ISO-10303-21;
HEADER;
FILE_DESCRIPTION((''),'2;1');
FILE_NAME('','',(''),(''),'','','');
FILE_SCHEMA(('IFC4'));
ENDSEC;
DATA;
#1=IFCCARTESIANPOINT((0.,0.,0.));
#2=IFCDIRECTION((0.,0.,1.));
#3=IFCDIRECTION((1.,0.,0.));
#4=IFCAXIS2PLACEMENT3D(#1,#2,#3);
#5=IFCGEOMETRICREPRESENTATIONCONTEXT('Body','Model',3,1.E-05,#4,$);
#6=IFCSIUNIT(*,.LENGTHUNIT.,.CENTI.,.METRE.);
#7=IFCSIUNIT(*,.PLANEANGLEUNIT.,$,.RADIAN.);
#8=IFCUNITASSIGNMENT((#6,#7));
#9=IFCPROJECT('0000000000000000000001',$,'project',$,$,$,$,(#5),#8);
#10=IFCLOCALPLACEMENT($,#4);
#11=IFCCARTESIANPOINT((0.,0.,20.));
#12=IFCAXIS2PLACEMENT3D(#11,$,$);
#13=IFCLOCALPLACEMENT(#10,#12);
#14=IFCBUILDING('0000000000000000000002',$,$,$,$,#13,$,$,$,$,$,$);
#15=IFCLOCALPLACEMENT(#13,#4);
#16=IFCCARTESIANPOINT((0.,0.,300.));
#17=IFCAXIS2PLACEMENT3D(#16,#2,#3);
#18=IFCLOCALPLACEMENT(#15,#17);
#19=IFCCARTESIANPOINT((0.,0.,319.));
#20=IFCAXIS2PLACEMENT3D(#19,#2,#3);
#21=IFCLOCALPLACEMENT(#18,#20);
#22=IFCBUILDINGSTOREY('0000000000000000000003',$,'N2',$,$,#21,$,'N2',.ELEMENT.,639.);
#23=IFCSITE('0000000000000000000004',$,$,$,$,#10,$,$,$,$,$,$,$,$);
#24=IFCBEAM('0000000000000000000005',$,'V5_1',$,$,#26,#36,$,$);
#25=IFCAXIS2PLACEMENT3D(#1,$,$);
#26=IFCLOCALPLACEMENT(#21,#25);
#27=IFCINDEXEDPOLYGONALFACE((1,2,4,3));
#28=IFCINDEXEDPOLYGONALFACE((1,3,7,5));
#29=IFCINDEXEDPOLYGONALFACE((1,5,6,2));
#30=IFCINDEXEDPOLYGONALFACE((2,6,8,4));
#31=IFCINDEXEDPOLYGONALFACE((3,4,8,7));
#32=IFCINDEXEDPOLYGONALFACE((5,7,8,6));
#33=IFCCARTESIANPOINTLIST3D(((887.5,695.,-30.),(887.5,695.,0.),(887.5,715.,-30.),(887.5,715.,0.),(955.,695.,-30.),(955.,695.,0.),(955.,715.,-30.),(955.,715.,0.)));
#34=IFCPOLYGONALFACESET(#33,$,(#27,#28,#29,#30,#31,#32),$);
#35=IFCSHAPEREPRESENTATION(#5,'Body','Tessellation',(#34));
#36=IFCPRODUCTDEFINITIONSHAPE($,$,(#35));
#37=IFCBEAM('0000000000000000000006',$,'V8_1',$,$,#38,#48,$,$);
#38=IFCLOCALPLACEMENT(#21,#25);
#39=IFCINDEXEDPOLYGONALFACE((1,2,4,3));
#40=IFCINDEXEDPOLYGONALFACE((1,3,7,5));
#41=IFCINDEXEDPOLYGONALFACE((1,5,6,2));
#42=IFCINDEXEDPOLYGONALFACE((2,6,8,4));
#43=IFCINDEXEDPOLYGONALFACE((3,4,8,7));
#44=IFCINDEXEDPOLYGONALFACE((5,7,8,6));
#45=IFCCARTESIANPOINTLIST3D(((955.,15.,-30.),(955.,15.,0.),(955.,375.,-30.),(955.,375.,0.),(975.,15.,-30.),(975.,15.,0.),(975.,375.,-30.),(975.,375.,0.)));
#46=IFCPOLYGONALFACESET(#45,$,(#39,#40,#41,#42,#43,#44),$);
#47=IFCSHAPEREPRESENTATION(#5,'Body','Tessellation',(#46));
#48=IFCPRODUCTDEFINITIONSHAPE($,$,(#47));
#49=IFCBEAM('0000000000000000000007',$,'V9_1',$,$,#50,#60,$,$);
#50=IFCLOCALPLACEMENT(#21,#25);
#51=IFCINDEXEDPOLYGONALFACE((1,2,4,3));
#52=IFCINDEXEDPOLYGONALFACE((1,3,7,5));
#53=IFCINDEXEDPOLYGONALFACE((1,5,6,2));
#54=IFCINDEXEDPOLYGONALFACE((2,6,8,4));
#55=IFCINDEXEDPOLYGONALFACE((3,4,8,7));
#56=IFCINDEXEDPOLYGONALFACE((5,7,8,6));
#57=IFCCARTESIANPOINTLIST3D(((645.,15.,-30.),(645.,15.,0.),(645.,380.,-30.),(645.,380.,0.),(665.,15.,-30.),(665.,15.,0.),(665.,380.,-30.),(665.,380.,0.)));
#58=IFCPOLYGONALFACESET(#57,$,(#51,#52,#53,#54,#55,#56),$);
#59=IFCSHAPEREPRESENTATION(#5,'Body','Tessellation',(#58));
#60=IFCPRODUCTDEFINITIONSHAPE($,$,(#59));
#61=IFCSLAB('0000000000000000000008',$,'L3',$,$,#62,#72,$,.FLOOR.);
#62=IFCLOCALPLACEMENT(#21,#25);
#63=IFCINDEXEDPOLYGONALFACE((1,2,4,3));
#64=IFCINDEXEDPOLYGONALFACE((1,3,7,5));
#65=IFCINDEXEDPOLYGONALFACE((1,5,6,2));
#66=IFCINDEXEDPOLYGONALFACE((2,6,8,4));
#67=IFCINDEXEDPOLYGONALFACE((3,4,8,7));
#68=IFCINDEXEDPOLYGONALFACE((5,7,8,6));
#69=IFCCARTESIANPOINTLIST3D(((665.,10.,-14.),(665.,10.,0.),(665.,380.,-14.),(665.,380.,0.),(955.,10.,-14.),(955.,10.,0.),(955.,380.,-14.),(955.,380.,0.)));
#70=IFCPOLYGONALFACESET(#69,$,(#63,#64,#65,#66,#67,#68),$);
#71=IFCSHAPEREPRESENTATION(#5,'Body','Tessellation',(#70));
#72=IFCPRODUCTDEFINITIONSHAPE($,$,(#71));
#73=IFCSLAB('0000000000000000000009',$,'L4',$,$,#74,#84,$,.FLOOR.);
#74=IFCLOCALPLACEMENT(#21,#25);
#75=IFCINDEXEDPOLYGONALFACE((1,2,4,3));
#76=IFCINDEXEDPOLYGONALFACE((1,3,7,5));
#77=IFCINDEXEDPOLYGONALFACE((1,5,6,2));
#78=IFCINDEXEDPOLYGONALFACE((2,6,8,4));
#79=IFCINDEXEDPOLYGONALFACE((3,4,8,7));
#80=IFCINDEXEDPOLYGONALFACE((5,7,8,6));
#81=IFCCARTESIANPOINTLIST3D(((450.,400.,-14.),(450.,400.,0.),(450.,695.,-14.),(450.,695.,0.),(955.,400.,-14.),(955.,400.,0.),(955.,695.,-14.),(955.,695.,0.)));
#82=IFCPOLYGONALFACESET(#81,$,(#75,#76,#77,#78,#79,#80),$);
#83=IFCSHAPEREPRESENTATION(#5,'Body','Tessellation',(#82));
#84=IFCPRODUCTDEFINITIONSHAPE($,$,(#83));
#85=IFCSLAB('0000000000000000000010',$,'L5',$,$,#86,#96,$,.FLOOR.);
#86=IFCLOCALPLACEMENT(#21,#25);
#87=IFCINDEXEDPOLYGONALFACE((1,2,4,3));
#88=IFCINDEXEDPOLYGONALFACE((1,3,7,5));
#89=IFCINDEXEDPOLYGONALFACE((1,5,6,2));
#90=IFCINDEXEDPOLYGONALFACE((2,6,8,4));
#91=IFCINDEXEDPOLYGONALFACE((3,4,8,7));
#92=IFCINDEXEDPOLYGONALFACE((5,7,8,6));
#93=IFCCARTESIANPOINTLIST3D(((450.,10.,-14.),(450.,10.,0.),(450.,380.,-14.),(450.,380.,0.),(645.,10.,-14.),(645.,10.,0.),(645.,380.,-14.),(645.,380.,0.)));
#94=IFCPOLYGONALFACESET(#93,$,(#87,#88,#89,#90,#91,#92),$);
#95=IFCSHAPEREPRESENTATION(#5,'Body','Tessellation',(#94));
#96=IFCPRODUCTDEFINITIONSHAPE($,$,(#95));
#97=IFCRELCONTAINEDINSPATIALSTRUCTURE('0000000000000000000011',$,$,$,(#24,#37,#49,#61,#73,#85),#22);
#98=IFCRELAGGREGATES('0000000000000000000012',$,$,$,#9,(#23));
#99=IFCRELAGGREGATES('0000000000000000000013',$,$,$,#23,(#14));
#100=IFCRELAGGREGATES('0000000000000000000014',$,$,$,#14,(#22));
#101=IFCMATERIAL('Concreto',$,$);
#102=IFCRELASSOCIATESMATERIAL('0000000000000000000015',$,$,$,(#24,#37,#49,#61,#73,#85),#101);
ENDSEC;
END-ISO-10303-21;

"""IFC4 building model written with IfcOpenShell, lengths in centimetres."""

from ifc_helpers import new_model, si_unit, frame, origin_with_axes, origin_2d_with_axis, place, context, project, spatial, polyline, rectangle, outline, extrude, material, element, save


model = new_model("IFC4")

# Units and contexts
model_context = context("Model", 3, precision=1e-05, world=origin_with_axes(), identifier="Body")
ifc_project = project(units=[si_unit("LENGTHUNIT", "METRE", prefix="CENTI"), si_unit("PLANEANGLEUNIT", "RADIAN")], contexts=[model_context])

# Site, building, storey
site_placement = place(None, origin_with_axes())
site = spatial("IfcSite", under=ifc_project, at=site_placement)
building_placement = place(site_placement, frame((0.0, 0.0, 20.0)))
building = spatial("IfcBuilding", under=site, at=building_placement)
placement_1 = place(building_placement, origin_with_axes())
placement_2 = place(placement_1, frame((0.0, 0.0, 300.0), z_axis=(0.0, 0.0, 1.0), x_axis=(1.0, 0.0, 0.0)))
storey_placement = place(placement_2, frame((0.0, 0.0, 319.0), z_axis=(0.0, 0.0, 1.0), x_axis=(1.0, 0.0, 0.0)))
storey = spatial("IfcBuildingStorey", under=building, at=storey_placement, Name="N2", LongName="N2", CompositionType="ELEMENT", Elevation=639.0)

# Shared definitions
ifc_material = material(Name="Concreto")

# Beams
beam_1_placement = place(storey_placement, frame((921.25, 705.0, 0.0), z_axis=(0.0, 0.0, 1.0), x_axis=(1.0, 0.0, 0.0)))
element("IfcBeam", 1, at=beam_1_placement, inside=storey, material=ifc_material, Name="V5_1", context=model_context, shape_type="SolidModel", body=[
    extrude(rectangle(XDim=20.0, YDim=30.0, at=origin_2d_with_axis()), frame((-33.75, 0.0, -15.0), z_axis=(1.0, 0.0, 0.0), x_axis=(0.0, 1.0, 0.0)), (0.0, 0.0, 1.0), 67.5),
])
beam_2_placement = place(storey_placement, frame((965.0, 195.0, 0.0), z_axis=(0.0, 0.0, 1.0), x_axis=(1.0, 0.0, 0.0)))
element("IfcBeam", 2, at=beam_2_placement, inside=storey, material=ifc_material, Name="V8_1", context=model_context, shape_type="SolidModel", body=[
    extrude(rectangle(XDim=20.0, YDim=30.0, at=origin_2d_with_axis()), frame((0.0, -180.0, -15.0), z_axis=(0.0, 1.0, 0.0), x_axis=(1.0, 0.0, 0.0)), (0.0, 0.0, 1.0), 360.0),
])
beam_3_placement = place(storey_placement, frame((655.0, 197.5, 0.0), z_axis=(0.0, 0.0, 1.0), x_axis=(1.0, 0.0, 0.0)))
element("IfcBeam", 3, at=beam_3_placement, inside=storey, material=ifc_material, Name="V9_1", context=model_context, shape_type="SolidModel", body=[
    extrude(rectangle(XDim=20.0, YDim=30.0, at=origin_2d_with_axis()), frame((0.0, -182.5, -15.0), z_axis=(0.0, 1.0, 0.0), x_axis=(1.0, 0.0, 0.0)), (0.0, 0.0, 1.0), 365.0),
])

# Slabs
slab_1_placement = place(storey_placement, frame((810.0, 195.0, 0.0), z_axis=(0.0, 0.0, 1.0), x_axis=(1.0, 0.0, 0.0)))
element("IfcSlab", 4, at=slab_1_placement, inside=storey, material=ifc_material, Name="L3", PredefinedType="FLOOR", context=model_context, shape_type="SolidModel", body=[
    extrude(outline(polyline([(145.0, 185.0), (-145.0, 185.0), (-145.0, -185.0), (145.0, -185.0), (145.0, 185.0), (145.0, 185.0)])), frame((0.0, 0.0, -14.0), z_axis=(0.0, 0.0, 1.0), x_axis=(1.0, 0.0, 0.0)), (0.0, 0.0, 1.0), 14.0),
])
slab_2_placement = place(storey_placement, frame((702.5, 547.5, 0.0), z_axis=(0.0, 0.0, 1.0), x_axis=(1.0, 0.0, 0.0)))
element("IfcSlab", 5, at=slab_2_placement, inside=storey, material=ifc_material, Name="L4", PredefinedType="FLOOR", context=model_context, shape_type="SolidModel", body=[
    extrude(outline(polyline([(252.5, 147.5), (-252.5, 147.5), (-252.5, -147.5), (252.5, -147.5), (252.5, 147.5), (252.5, 147.5)])), frame((0.0, 0.0, -14.0), z_axis=(0.0, 0.0, 1.0), x_axis=(1.0, 0.0, 0.0)), (0.0, 0.0, 1.0), 14.0),
])
slab_3_placement = place(storey_placement, frame((547.5, 195.0, 0.0), z_axis=(0.0, 0.0, 1.0), x_axis=(1.0, 0.0, 0.0)))
element("IfcSlab", 6, at=slab_3_placement, inside=storey, material=ifc_material, Name="L5", PredefinedType="FLOOR", context=model_context, shape_type="SolidModel", body=[
    extrude(outline(polyline([(97.5, 185.0), (-97.5, 185.0), (-97.5, -185.0), (97.5, -185.0), (97.5, 185.0), (97.5, 185.0)])), frame((0.0, 0.0, -14.0), z_axis=(0.0, 0.0, 1.0), x_axis=(1.0, 0.0, 0.0)), (0.0, 0.0, 1.0), 14.0),
])

save(model, "model.ifc")
